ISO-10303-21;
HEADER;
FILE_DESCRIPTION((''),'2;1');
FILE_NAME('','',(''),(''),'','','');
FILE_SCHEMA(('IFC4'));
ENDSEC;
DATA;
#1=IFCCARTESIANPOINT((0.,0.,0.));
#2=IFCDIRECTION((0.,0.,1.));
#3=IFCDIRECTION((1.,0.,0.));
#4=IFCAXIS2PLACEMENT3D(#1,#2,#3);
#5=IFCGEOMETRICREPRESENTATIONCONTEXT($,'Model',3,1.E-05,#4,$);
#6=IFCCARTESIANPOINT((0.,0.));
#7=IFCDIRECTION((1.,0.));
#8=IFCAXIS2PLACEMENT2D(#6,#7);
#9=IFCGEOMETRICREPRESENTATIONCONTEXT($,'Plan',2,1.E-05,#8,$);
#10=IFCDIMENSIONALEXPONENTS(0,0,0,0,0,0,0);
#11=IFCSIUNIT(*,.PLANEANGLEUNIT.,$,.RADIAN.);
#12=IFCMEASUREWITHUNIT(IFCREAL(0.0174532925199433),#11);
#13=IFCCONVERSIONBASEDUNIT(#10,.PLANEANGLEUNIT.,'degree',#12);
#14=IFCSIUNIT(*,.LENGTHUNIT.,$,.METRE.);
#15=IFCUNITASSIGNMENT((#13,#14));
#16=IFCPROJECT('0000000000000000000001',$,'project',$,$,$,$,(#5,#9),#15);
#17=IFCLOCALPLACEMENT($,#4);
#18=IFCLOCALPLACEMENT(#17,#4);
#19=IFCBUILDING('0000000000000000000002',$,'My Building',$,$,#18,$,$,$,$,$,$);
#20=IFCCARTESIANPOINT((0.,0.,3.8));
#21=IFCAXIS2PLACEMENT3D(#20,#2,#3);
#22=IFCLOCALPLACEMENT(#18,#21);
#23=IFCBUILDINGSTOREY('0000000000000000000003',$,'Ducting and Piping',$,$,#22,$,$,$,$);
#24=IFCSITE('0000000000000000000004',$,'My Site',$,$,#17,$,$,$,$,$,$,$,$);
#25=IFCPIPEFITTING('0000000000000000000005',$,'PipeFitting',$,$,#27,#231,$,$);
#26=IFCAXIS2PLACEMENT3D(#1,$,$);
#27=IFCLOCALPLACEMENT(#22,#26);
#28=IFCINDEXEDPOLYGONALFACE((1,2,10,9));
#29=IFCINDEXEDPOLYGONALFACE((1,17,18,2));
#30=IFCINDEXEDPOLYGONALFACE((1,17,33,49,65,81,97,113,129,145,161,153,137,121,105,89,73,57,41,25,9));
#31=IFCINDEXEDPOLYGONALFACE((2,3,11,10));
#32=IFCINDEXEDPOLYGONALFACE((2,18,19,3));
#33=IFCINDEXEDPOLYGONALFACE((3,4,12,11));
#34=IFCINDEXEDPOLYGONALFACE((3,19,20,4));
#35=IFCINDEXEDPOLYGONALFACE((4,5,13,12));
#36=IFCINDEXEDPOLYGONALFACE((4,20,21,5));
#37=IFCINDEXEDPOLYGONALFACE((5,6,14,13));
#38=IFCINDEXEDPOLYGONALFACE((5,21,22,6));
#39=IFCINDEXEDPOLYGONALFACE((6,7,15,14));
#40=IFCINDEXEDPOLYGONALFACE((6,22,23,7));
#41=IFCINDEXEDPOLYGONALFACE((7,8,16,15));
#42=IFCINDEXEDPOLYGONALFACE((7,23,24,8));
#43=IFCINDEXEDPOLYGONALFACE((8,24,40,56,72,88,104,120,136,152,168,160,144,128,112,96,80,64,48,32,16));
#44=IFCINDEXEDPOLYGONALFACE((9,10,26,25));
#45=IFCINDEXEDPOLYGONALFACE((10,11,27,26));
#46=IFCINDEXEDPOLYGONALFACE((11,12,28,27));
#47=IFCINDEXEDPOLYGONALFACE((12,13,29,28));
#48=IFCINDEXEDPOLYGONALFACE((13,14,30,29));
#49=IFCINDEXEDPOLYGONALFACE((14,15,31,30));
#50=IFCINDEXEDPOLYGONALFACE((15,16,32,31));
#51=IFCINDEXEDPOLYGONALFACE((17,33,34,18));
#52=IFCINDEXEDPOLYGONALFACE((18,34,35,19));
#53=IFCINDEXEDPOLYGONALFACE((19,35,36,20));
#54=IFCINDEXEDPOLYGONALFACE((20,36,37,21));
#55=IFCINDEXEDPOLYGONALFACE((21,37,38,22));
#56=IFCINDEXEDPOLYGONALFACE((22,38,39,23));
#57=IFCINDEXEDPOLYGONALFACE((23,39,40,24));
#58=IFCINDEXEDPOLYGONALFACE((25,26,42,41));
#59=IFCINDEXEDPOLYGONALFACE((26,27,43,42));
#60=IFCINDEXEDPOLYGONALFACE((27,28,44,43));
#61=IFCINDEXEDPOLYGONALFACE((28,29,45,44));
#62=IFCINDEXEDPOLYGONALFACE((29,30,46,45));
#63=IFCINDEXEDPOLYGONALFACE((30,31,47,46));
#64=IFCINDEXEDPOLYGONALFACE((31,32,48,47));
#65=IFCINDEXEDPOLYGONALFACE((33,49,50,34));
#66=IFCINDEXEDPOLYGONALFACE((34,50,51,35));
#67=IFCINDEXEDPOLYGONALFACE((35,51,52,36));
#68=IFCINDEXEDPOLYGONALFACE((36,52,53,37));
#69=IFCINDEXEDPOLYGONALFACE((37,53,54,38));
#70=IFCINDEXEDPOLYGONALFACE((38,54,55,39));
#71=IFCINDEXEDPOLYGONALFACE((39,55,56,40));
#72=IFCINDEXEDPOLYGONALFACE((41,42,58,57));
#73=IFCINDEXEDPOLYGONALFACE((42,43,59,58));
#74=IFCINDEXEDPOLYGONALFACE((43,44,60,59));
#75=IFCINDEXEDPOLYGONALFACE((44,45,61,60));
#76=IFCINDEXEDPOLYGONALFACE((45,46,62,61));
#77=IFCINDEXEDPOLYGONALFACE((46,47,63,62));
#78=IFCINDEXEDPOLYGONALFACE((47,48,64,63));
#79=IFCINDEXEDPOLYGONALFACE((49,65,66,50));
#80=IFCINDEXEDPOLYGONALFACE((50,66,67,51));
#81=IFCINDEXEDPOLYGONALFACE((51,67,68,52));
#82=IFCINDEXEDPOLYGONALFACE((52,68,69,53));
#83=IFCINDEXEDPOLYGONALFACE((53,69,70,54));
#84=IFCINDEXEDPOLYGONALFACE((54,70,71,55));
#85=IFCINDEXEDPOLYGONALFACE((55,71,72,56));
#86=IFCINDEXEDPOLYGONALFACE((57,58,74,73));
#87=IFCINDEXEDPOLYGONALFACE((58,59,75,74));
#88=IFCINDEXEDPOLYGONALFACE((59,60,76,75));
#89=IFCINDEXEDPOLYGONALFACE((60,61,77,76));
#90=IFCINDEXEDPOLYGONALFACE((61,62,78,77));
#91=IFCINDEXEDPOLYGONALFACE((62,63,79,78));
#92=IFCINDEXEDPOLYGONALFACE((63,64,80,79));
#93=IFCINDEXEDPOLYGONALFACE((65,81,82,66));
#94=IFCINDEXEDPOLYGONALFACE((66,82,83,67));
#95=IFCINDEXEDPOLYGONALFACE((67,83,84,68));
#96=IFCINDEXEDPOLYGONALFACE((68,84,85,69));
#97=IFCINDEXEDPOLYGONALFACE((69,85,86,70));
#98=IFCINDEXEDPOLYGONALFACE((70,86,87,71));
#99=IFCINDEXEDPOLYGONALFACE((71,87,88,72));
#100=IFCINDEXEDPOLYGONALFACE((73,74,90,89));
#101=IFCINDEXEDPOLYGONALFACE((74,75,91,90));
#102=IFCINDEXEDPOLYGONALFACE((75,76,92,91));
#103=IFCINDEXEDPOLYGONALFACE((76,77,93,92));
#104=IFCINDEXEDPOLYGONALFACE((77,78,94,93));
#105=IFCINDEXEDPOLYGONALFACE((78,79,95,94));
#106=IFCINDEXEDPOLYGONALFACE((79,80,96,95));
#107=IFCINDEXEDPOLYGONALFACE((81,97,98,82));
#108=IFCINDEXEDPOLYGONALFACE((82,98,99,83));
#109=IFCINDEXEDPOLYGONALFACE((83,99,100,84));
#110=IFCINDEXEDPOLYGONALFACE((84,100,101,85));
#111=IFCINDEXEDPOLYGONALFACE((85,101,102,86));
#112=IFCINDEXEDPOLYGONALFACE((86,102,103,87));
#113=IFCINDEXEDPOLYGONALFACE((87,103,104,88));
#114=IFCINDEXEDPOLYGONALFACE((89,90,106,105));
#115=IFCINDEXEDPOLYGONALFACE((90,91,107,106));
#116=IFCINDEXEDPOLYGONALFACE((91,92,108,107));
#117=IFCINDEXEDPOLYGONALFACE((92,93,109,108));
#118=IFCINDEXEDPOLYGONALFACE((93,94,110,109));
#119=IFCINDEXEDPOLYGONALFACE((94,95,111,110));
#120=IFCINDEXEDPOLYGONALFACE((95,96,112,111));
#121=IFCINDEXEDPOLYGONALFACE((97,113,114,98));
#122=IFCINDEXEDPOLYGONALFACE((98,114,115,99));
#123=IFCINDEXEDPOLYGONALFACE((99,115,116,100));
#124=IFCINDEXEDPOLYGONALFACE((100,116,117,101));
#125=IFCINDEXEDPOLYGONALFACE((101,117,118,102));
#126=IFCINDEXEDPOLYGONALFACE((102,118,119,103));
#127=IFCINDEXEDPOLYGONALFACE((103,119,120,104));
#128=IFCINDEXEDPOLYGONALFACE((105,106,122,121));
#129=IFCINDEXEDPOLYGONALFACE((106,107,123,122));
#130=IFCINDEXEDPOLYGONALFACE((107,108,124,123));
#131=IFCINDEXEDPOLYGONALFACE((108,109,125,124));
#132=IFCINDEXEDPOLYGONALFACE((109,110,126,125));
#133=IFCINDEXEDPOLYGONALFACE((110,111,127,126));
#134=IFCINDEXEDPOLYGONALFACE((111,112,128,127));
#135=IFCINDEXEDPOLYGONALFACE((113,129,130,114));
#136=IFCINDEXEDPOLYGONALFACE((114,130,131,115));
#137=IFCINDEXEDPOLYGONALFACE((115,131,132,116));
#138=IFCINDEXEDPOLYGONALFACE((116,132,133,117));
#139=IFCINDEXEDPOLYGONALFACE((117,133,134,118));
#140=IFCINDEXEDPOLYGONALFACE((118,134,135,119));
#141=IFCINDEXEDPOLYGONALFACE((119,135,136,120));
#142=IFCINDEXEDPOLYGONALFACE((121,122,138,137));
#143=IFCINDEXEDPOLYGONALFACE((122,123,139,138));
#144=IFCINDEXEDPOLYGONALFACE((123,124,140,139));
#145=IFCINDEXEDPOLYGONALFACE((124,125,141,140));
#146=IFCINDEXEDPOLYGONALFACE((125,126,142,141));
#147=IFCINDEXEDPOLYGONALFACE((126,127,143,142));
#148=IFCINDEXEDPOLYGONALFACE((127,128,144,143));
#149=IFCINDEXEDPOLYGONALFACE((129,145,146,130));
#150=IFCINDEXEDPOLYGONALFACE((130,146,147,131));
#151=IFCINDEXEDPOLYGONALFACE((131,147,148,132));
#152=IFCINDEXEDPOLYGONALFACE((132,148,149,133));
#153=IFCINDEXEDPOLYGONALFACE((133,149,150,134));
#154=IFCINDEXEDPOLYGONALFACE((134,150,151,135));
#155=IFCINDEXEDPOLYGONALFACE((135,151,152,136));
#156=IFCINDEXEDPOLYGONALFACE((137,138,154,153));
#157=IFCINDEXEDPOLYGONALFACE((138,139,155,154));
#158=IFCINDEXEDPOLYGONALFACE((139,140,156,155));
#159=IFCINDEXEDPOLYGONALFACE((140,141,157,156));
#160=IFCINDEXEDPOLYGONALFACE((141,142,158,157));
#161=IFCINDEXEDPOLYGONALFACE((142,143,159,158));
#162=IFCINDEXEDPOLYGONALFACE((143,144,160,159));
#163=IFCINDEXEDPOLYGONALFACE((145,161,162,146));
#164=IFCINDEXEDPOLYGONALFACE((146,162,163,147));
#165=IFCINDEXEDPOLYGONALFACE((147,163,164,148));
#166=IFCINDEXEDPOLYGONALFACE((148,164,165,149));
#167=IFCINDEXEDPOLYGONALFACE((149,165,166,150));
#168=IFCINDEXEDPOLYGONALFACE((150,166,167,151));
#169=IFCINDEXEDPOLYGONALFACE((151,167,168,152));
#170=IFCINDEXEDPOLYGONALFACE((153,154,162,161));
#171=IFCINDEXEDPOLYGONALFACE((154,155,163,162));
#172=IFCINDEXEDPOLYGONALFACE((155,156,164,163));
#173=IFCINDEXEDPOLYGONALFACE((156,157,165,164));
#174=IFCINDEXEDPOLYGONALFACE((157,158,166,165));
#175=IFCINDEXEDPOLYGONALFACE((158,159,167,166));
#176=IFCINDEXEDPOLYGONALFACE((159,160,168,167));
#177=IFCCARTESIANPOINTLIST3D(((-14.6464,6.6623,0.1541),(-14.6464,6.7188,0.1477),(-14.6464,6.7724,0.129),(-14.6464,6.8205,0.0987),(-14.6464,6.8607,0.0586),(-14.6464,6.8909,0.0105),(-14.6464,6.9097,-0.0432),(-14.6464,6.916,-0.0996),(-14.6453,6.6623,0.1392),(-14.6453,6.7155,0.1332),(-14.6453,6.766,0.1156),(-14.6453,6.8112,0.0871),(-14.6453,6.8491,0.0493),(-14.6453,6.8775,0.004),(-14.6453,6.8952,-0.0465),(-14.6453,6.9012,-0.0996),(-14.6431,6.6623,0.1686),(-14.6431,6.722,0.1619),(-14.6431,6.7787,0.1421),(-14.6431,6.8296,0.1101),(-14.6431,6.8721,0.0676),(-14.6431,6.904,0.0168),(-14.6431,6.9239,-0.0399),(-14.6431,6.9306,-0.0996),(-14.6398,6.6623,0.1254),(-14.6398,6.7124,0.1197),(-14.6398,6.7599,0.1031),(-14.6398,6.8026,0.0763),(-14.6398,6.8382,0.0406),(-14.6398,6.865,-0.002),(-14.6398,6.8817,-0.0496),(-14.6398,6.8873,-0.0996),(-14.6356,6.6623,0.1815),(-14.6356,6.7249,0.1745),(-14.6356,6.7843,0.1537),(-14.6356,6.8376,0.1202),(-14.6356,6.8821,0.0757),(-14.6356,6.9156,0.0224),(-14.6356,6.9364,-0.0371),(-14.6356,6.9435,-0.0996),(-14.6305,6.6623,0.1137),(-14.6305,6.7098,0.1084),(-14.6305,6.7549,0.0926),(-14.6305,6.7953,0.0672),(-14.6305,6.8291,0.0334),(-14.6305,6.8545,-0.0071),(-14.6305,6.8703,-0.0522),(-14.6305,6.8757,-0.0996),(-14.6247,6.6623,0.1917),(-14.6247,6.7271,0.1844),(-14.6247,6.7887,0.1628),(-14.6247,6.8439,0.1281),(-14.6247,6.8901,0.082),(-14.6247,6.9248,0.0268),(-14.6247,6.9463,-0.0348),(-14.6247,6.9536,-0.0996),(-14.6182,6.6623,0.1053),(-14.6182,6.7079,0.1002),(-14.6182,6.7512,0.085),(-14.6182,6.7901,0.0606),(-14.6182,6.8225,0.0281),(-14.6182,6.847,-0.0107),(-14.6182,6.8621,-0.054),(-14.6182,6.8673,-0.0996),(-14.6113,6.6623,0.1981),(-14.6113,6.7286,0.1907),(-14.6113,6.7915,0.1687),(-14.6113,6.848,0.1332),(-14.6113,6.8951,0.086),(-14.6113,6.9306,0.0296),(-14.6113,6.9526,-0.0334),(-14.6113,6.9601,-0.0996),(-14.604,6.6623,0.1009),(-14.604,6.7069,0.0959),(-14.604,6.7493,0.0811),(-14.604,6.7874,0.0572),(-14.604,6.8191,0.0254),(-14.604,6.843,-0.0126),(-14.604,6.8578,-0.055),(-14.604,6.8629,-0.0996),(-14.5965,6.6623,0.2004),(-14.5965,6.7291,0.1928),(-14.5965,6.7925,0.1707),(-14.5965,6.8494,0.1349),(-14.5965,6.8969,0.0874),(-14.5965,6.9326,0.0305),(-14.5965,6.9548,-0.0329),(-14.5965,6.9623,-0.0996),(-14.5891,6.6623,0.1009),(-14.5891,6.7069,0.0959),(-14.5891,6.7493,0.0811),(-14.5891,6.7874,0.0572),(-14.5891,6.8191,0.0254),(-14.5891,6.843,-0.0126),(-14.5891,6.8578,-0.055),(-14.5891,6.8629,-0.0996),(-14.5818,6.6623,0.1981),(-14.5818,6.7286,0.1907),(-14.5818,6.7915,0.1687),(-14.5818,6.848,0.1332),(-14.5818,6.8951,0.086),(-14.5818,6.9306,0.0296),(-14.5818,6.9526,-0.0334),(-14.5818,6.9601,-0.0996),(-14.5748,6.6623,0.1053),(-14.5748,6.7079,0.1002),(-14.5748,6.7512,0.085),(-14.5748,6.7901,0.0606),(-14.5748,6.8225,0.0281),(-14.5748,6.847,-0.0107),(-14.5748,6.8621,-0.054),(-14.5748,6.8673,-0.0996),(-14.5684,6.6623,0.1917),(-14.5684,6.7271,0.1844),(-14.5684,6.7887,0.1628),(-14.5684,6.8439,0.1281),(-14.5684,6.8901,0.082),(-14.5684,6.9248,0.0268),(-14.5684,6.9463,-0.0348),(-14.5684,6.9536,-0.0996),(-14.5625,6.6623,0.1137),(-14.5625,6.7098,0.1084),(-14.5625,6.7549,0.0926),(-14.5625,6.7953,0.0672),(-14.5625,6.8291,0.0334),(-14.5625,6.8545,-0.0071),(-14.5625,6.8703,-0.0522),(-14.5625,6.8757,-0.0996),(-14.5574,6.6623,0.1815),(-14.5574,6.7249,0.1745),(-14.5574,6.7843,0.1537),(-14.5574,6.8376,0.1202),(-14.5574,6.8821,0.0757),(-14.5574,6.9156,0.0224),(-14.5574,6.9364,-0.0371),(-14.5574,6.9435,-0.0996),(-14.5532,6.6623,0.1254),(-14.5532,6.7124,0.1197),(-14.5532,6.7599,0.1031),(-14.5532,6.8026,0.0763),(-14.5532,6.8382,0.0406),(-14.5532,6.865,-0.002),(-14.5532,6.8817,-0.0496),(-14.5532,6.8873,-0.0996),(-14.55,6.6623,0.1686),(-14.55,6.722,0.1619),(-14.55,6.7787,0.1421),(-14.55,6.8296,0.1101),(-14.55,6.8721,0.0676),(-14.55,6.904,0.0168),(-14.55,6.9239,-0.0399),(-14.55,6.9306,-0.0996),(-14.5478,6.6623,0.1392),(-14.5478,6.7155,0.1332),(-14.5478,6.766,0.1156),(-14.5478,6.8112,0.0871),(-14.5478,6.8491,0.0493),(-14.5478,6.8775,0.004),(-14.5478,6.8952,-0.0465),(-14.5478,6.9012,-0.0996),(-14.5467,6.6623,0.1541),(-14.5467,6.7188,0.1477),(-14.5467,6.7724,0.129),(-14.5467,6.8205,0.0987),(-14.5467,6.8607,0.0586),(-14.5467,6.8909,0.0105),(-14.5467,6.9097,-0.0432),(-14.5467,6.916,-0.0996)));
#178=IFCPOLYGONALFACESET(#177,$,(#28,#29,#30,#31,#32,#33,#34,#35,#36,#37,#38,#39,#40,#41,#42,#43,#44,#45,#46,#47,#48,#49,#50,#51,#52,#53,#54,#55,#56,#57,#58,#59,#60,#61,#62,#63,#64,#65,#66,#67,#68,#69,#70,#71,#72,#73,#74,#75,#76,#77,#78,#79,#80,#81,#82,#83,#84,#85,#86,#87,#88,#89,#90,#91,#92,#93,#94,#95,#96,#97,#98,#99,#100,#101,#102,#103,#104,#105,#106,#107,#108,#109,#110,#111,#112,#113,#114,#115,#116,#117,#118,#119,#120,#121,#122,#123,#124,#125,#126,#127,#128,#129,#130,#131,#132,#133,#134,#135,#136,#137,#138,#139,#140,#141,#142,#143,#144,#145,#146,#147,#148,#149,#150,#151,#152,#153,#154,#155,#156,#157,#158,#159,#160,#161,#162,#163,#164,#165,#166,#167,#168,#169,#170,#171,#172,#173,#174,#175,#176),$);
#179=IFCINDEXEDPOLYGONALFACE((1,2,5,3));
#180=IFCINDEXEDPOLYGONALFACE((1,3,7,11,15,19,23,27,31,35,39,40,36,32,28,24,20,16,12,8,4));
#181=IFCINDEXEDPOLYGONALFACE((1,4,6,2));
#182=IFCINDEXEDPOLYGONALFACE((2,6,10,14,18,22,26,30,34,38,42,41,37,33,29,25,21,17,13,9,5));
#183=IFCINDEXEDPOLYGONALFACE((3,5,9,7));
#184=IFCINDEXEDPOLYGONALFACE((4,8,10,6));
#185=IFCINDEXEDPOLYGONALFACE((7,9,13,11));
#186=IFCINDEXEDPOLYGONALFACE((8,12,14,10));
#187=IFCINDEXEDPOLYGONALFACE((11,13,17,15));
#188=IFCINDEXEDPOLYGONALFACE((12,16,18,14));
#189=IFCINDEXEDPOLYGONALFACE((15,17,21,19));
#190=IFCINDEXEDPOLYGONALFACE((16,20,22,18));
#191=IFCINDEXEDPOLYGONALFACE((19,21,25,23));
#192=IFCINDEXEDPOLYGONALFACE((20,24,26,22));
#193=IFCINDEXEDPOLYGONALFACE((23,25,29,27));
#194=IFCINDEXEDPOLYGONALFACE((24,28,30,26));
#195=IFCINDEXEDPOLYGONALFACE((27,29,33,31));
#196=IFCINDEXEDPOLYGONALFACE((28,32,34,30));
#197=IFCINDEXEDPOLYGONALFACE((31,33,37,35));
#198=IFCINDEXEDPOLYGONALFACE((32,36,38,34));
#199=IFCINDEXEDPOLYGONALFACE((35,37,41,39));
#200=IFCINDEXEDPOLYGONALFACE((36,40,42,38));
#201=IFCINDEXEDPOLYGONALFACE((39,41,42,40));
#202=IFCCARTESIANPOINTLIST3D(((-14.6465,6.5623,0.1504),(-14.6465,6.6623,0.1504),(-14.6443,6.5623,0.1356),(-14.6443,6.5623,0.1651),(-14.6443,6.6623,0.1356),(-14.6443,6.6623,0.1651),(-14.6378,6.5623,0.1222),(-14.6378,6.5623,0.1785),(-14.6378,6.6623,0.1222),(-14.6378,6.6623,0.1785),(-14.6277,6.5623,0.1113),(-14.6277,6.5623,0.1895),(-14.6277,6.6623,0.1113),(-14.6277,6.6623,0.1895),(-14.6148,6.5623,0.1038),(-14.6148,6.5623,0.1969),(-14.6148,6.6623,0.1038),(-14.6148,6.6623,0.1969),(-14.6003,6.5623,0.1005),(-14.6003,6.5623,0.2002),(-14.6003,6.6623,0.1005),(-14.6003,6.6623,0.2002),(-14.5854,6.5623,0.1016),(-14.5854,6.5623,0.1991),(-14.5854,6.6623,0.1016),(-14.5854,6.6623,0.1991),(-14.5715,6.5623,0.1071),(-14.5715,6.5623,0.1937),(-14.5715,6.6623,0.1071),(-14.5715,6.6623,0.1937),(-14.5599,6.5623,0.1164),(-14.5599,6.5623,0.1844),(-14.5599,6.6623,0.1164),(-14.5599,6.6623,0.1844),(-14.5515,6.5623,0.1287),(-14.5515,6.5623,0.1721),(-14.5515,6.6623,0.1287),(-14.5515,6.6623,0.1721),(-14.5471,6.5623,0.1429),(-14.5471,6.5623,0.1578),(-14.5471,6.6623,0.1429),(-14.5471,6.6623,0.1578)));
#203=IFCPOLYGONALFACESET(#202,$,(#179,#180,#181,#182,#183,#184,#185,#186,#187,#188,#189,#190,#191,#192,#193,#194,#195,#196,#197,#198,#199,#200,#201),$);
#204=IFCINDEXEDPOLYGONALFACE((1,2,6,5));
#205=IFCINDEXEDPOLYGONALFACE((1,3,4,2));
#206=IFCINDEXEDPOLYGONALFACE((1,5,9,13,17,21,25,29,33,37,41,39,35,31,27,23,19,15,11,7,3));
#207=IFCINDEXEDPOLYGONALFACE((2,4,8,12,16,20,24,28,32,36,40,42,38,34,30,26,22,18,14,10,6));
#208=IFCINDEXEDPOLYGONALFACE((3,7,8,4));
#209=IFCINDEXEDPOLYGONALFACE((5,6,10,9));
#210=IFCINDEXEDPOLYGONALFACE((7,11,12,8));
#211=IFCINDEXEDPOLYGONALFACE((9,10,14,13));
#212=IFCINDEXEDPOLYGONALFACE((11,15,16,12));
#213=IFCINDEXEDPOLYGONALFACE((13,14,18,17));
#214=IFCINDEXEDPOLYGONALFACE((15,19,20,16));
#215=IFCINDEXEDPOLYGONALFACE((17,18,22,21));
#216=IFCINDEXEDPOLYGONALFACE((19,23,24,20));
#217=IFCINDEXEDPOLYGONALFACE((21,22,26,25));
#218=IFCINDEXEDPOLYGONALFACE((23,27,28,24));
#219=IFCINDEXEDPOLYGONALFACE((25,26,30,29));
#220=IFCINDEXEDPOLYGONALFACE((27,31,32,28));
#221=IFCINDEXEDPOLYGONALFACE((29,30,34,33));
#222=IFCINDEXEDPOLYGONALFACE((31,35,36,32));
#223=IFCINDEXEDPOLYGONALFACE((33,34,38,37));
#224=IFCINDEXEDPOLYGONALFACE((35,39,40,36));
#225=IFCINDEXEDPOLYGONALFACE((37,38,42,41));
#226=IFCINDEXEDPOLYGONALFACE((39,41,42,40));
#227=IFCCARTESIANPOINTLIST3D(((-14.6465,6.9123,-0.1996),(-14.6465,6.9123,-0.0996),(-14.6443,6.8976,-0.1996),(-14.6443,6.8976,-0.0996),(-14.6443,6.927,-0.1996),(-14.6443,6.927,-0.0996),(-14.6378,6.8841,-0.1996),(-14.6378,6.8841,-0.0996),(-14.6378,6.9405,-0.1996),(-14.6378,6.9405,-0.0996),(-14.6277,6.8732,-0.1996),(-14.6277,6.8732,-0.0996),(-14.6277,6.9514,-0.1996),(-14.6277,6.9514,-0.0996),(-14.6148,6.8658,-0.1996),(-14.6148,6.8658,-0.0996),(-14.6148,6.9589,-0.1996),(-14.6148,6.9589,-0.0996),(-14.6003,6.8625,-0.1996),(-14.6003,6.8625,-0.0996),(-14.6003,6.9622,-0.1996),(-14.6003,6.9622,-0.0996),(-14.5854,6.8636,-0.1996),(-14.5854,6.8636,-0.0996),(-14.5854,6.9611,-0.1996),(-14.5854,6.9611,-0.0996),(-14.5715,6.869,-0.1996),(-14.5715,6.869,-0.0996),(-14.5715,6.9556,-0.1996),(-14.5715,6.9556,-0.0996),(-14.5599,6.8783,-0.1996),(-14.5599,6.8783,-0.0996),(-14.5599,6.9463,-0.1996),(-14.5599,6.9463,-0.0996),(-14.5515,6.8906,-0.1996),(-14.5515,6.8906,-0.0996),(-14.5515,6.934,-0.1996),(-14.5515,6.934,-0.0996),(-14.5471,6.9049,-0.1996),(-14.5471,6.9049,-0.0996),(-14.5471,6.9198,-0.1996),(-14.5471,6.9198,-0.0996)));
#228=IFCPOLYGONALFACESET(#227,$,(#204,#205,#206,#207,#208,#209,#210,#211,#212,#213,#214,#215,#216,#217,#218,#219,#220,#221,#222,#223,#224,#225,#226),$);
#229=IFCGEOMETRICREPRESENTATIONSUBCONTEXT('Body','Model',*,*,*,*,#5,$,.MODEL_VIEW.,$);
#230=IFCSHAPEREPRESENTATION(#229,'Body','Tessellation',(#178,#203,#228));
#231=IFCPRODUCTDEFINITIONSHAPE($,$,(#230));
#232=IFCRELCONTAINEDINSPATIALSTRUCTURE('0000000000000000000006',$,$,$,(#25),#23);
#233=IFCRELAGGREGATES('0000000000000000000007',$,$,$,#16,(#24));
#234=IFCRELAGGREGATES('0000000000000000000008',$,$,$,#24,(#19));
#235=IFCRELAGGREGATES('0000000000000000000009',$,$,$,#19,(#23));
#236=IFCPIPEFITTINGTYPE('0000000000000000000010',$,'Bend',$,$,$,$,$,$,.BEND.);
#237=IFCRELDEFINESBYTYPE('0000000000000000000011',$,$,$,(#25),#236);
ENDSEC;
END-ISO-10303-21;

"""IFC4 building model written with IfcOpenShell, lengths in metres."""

from ifc_helpers import new_model, entity, si_unit, converted_unit, frame, origin_with_axes, origin_2d_with_axis, place, context, subcontext, project, spatial, circle, extrude, source, transform, mapped, type_object, type_shapes, element, save


model = new_model("IFC4")

# Units and contexts
model_context = context("Model", 3, precision=1e-05, world=origin_with_axes())
plan_context = context("Plan", 2, precision=1e-05, world=origin_2d_with_axis())
body_context = subcontext(model_context, "Body", "Model", "MODEL_VIEW")
ifc_project = project(units=[converted_unit("PLANEANGLEUNIT", "degree", entity("IfcReal", 0.0174532925199433), si_unit("PLANEANGLEUNIT", "RADIAN"), dimensions=[0, 0, 0, 0, 0, 0, 0]), si_unit("LENGTHUNIT", "METRE")], contexts=[model_context, plan_context])

# Site, building, storey
site_placement = place(None, origin_with_axes())
site = spatial("IfcSite", under=ifc_project, at=site_placement, Name="My Site")
building_placement = place(site_placement, origin_with_axes())
building = spatial("IfcBuilding", under=site, at=building_placement, Name="My Building")
storey_placement = place(building_placement, frame((0.0, 0.0, 3.8), z_axis=(0.0, 0.0, 1.0), x_axis=(1.0, 0.0, 0.0)))
storey = spatial("IfcBuildingStorey", under=building, at=storey_placement, Name="Ducting and Piping")

# Pipe fitting
pipe_fitting_type = type_object("IfcPipeFittingType", Name="Bend", PredefinedType="BEND")
shared_shape = source(origin_with_axes(), body_context, "Body", "SolidModel", [
    entity("IfcSweptDiskSolid", entity("IfcIndexedPolyCurve", entity("IfcCartesianPointList3D", [[0.0, 0.0, 0.1], [0.0, -0.0732, 0.2768], [0.0, -0.25, 0.35]]), [entity("IfcArcIndex", [1, 2, 3])]), 0.05),
    extrude(circle(Radius=0.05), origin_with_axes(), (0.0, 0.0, 1.0), 0.1),
    extrude(circle(Radius=0.05), frame((0.0, -0.25, 0.35), z_axis=(0.0, -1.0, 0.0), x_axis=(1.0, 0.0, 0.0)), (0.0, 0.0, 1.0), 0.1),
])
type_shapes(pipe_fitting_type, [shared_shape])
for number, where, z_axis, x_axis, name in (
    (1, (-14.5965, 6.5623, 0.1504), (0.0, 1.0, 0.0), (-1.0, 0.0, 0.0), "PipeFitting"),
):
    element("IfcPipeFitting", number, at=place(storey_placement, frame(where, z_axis=z_axis, x_axis=x_axis)), inside=storey, type_object=pipe_fitting_type, Name=name, context=body_context, shape_type="MappedRepresentation", body=[
        mapped(shared_shape, transform((0.0, 0.0, 0.0), x_axis=(1.0, 0.0, 0.0), y_axis=(0.0, 1.0, 0.0), z_axis=(0.0, 0.0, 1.0), scale=1.0)),
    ])

save(model, "model.ifc")
